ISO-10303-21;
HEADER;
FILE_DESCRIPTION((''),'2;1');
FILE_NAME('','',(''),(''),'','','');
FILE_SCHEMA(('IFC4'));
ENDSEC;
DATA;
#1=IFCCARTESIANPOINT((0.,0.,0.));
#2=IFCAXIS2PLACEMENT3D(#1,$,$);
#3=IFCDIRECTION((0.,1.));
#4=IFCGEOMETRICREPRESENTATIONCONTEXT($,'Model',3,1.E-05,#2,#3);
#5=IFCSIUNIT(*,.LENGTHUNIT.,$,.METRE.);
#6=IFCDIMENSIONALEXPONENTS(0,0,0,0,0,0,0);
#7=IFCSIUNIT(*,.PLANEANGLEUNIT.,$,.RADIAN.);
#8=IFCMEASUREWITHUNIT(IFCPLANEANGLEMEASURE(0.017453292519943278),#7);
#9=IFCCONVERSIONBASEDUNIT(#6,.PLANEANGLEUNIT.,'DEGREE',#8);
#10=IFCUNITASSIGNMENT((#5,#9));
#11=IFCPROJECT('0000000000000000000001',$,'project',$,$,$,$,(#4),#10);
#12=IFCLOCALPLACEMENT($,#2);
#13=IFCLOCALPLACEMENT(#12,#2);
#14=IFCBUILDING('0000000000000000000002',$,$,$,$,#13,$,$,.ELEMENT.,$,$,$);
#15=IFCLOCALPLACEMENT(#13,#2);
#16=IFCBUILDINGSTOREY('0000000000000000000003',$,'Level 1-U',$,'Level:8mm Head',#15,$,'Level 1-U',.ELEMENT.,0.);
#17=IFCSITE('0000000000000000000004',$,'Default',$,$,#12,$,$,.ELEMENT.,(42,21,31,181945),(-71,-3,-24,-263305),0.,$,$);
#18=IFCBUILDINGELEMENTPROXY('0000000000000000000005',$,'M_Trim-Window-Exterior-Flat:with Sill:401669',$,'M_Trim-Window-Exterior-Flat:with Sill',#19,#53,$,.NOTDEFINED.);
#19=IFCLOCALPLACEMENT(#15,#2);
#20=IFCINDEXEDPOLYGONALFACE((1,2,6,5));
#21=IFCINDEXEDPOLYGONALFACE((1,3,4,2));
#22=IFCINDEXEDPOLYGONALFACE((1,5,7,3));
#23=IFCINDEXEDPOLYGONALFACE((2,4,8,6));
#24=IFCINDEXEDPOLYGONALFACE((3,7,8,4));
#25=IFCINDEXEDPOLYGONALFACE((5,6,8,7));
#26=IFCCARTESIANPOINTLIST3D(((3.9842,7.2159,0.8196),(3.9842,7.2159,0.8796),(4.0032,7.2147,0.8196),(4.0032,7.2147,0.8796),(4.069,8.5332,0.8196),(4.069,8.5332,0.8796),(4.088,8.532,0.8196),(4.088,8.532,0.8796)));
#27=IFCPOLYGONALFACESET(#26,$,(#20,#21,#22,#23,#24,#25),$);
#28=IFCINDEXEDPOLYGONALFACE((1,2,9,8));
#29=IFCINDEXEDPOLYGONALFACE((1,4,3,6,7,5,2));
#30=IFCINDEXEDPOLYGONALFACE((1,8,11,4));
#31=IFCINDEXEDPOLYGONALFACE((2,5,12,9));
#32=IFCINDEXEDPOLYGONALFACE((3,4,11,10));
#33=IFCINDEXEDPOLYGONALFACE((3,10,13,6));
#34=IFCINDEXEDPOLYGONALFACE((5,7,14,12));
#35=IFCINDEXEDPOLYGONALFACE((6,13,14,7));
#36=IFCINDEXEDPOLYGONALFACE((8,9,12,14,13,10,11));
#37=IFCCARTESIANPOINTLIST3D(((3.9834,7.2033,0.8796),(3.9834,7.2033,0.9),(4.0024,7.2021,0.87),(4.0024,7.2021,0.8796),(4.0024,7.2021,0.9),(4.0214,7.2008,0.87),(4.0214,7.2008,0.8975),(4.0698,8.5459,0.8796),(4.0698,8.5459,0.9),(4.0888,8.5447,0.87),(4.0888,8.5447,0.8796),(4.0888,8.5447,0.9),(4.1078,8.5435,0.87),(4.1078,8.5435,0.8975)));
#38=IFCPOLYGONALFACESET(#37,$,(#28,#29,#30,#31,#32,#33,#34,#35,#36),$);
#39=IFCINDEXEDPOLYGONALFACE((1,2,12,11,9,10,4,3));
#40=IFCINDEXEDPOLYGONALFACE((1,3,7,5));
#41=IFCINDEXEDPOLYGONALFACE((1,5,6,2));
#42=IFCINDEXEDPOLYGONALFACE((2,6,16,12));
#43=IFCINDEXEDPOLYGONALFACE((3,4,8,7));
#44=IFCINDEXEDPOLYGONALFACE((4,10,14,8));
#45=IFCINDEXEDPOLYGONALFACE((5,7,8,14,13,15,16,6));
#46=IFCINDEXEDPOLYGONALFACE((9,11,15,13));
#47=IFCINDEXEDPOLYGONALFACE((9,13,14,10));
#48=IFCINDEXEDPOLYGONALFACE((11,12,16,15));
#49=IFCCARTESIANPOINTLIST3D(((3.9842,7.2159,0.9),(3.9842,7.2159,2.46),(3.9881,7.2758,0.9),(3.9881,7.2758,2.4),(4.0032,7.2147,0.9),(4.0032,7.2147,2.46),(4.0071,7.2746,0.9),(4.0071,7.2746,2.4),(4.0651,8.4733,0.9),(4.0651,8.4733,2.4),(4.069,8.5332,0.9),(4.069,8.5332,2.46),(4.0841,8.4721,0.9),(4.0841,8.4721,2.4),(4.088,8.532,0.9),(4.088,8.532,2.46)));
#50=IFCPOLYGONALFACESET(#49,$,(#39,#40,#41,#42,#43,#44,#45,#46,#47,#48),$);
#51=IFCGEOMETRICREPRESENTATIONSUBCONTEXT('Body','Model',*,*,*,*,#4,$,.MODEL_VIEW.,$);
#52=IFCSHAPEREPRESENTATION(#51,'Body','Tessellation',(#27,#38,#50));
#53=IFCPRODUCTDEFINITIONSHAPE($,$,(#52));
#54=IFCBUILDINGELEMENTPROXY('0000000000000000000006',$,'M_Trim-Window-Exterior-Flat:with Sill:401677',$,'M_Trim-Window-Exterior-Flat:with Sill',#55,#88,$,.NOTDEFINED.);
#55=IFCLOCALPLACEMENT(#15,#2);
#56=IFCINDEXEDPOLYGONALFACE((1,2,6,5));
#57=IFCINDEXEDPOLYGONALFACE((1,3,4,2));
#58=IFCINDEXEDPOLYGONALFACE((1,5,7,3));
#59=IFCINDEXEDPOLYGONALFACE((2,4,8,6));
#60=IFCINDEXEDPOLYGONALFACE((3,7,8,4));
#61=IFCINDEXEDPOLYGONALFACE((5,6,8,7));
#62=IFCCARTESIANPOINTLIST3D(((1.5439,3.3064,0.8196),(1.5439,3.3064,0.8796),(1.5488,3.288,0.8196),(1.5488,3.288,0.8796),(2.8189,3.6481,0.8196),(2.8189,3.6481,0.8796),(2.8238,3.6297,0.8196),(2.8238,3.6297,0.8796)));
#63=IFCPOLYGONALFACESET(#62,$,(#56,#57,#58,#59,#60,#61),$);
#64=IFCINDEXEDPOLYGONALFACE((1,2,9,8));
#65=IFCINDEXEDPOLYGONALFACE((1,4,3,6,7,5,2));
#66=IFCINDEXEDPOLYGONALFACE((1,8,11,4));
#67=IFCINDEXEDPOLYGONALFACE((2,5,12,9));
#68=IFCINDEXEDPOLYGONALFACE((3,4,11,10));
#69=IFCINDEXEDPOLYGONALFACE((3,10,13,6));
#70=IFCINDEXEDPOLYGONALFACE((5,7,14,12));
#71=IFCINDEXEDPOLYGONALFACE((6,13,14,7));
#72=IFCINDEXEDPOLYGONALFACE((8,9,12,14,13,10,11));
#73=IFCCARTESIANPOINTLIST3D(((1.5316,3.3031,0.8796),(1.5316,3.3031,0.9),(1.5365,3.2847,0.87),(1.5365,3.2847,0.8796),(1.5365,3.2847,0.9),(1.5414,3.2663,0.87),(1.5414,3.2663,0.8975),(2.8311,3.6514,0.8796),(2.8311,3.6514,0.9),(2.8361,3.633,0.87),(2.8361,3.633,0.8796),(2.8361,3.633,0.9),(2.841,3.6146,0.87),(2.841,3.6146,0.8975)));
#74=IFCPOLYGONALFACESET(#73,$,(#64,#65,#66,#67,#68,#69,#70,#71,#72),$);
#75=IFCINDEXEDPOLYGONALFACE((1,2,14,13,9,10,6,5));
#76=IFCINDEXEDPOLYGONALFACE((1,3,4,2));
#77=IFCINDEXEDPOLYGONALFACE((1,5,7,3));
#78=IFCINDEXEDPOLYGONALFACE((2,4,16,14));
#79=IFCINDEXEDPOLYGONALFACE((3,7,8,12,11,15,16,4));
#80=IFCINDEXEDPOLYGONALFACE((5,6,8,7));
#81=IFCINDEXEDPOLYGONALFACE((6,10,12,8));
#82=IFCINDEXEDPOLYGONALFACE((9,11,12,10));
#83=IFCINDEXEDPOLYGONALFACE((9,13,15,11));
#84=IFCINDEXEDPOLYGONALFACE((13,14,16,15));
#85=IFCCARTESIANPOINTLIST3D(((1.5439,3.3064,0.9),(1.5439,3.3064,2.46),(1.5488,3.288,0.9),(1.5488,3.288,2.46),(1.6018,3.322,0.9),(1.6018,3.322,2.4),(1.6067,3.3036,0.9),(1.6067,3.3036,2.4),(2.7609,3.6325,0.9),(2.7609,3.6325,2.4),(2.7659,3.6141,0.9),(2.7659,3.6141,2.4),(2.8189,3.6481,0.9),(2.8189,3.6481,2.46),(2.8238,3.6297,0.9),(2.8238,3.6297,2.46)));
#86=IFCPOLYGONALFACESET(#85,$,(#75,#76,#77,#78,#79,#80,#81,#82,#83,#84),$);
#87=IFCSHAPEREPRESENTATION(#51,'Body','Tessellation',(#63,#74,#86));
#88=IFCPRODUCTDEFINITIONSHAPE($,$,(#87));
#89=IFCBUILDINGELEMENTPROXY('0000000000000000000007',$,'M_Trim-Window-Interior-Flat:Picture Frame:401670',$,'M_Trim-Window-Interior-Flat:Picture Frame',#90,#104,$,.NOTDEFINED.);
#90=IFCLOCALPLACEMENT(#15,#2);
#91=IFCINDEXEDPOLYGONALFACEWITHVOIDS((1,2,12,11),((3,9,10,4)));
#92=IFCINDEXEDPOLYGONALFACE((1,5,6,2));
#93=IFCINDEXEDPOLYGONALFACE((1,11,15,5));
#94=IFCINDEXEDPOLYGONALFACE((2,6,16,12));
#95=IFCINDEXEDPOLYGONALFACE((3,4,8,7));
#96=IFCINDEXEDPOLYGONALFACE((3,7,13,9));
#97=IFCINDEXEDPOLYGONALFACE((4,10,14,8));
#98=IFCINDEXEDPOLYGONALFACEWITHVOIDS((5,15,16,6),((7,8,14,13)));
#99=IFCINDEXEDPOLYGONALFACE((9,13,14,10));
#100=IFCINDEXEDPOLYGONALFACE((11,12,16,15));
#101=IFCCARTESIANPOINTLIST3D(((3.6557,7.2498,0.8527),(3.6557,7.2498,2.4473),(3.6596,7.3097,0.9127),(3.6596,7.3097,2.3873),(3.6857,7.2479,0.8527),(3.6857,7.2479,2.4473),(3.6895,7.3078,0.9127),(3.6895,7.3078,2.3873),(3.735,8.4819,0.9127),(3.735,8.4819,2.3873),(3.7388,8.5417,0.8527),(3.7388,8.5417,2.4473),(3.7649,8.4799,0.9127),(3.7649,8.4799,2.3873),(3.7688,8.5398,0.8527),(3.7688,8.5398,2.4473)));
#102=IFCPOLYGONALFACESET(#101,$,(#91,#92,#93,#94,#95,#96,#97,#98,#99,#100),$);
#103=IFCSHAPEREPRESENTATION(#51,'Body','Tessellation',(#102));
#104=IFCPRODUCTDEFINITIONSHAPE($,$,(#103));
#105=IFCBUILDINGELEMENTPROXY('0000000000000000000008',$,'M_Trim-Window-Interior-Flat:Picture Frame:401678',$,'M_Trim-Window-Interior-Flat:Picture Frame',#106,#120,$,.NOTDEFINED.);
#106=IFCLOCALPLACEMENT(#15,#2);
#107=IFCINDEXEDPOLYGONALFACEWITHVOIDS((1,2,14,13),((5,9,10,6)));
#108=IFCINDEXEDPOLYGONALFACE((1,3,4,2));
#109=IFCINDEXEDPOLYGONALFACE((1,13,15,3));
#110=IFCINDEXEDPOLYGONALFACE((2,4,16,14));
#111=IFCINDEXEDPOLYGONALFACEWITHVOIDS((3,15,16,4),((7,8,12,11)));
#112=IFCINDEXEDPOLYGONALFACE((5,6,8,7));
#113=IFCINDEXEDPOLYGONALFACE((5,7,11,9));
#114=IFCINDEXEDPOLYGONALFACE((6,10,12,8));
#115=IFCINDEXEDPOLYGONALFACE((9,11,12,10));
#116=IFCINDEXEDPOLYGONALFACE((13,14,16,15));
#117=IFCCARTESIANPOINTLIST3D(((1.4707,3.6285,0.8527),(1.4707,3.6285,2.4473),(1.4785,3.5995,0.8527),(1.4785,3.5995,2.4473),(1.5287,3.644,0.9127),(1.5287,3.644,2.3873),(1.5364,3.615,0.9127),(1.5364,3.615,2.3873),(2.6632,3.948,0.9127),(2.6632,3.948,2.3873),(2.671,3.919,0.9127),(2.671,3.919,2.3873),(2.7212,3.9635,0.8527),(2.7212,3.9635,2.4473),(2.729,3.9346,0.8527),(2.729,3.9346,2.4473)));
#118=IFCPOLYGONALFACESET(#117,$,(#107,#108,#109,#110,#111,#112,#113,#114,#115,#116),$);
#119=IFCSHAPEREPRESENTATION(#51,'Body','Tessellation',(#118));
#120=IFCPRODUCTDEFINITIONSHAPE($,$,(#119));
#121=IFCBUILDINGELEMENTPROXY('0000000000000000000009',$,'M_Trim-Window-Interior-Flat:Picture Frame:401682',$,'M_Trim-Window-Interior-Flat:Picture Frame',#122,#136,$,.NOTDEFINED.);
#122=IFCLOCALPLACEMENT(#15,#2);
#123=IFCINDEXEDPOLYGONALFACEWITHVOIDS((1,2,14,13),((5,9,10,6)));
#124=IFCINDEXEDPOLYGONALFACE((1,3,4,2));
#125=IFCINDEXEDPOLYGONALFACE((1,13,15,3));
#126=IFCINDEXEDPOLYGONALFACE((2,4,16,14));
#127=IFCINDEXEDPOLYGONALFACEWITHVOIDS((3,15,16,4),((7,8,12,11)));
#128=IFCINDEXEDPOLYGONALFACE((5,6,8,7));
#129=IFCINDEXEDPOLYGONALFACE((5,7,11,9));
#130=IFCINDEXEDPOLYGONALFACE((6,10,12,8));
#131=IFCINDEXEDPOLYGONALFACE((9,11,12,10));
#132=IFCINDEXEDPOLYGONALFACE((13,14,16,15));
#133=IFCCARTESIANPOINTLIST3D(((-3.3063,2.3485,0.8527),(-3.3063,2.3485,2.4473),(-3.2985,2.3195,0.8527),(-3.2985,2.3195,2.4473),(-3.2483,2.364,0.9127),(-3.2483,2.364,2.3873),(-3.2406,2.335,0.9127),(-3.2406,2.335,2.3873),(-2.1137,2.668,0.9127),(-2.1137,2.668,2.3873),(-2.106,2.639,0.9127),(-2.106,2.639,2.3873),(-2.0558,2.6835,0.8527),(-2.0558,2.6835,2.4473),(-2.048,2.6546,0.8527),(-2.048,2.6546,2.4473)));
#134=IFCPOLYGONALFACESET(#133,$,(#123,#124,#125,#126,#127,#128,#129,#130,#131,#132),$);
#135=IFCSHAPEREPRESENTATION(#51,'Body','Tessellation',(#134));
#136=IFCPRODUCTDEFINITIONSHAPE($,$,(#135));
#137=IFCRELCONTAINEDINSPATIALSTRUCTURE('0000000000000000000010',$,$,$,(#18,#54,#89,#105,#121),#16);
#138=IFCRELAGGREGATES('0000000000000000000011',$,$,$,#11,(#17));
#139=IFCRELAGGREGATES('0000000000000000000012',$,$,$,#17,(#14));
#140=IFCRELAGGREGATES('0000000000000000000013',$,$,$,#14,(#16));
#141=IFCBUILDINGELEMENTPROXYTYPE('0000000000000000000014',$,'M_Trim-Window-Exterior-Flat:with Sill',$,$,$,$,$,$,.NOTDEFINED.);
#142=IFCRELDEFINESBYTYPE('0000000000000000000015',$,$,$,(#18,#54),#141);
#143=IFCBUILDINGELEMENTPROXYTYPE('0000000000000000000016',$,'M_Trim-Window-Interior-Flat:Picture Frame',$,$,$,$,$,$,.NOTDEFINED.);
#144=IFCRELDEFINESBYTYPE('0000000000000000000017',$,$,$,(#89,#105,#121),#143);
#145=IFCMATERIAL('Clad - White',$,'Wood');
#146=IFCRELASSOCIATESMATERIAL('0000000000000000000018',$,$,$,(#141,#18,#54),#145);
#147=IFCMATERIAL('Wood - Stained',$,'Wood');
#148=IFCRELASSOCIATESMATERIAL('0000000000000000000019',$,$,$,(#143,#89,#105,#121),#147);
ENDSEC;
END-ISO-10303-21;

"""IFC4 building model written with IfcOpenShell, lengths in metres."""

from ifc_helpers import new_model, entity, si_unit, converted_unit, direction, frame, frame_2d, origin, place, context, subcontext, project, spatial, polyline, rectangle, outline, extrude, source, transform, mapped, material, type_object, type_shapes, element, save


model = new_model("IFC4")

# Units and contexts
model_context = context("Model", 3, precision=1e-05, world=origin(), true_north=direction((0.0, 1.0)))
body_context = subcontext(model_context, "Body", "Model", "MODEL_VIEW")
ifc_project = project(units=[si_unit("LENGTHUNIT", "METRE"), converted_unit("PLANEANGLEUNIT", "DEGREE", entity("IfcPlaneAngleMeasure", 0.017453292519943278), si_unit("PLANEANGLEUNIT", "RADIAN"), dimensions=[0, 0, 0, 0, 0, 0, 0])], contexts=[model_context])

# Site, building, storey
site_placement = place(None, origin())
site = spatial("IfcSite", under=ifc_project, at=site_placement, Name="Default", CompositionType="ELEMENT", RefLatitude=(42, 21, 31, 181945), RefLongitude=(-71, -3, -24, -263305), RefElevation=0.0)
building_placement = place(site_placement, origin())
building = spatial("IfcBuilding", under=site, at=building_placement, CompositionType="ELEMENT")
storey_placement = place(building_placement, origin())
storey = spatial("IfcBuildingStorey", under=building, at=storey_placement, Name="Level 1-U", ObjectType="Level:8mm Head", LongName="Level 1-U", CompositionType="ELEMENT", Elevation=0.0)

# Building element proxies
ifc_material_1 = material(Name="Clad - White", Category="Wood")
ifc_material_2 = material(Name="Wood - Stained", Category="Wood")
building_element_proxy_type_1 = type_object("IfcBuildingElementProxyType", Name="M_Trim-Window-Exterior-Flat:with Sill", PredefinedType="NOTDEFINED", material=ifc_material_1)
shared_shape_1 = source(origin(), body_context, "Body", "SweptSolid", [
    extrude(rectangle(XDim=1.32, YDim=0.06, at=frame_2d((0.0, 0.0), x_axis=(1.0, 0.0))), frame((0.0, -1.5504, 0.0), z_axis=(0.0, 0.0, 1.0), x_axis=(-1.0, 0.0, 0.0)), (0.0, 0.0, 1.0), 0.019),
    extrude(outline(polyline([(-0.019, -0.0152), (0.0, -0.0152), (0.0, -0.0057), (0.019, -0.0057), (0.019, 0.0148), (0.0, 0.0148), (-0.019, 0.0123), (-0.019, -0.0152)])), frame((-0.6727, -1.5148, 0.019), z_axis=(1.0, 0.0, 0.0), x_axis=(0.0, 0.0, -1.0)), (0.0, 0.0, 1.0), 1.3454),
    extrude(outline(polyline([(-0.795, -0.66), (0.765, -0.66), (0.765, -0.6), (-0.735, -0.6), (-0.735, 0.6), (0.765, 0.6), (0.765, 0.66), (-0.795, 0.66), (-0.795, -0.66)])), frame((0.0, -0.735, 0.0), z_axis=(0.0, 0.0, 1.0), x_axis=(0.0, -1.0, 0.0)), (0.0, 0.0, 1.0), 0.019),
])
type_shapes(building_element_proxy_type_1, [shared_shape_1])
for number, where, z_axis, x_axis, name in (
    (1, (4.0266, 7.8746, 2.4), (0.997938, -0.064186, 0.0), (0.064186, 0.997938, 0.0), "M_Trim-Window-Exterior-Flat:with Sill:401669"),
    (2, (2.1814, 3.4772, 2.4), (0.258819, -0.965926, 0.0), (0.965926, 0.258819, 0.0), "M_Trim-Window-Exterior-Flat:with Sill:401677"),
):
    element("IfcBuildingElementProxy", number, at=place(storey_placement, frame(where, z_axis=z_axis, x_axis=x_axis)), inside=storey, type_object=building_element_proxy_type_1, material=ifc_material_1, Name=name, ObjectType="M_Trim-Window-Exterior-Flat:with Sill", PredefinedType="NOTDEFINED", context=body_context, shape_type="MappedRepresentation", body=[
        mapped(shared_shape_1, transform((0.0, 0.0, 0.0), scale=1.0)),
    ])
building_element_proxy_type_2 = type_object("IfcBuildingElementProxyType", Name="M_Trim-Window-Interior-Flat:Picture Frame", PredefinedType="NOTDEFINED", material=ifc_material_2)
shared_shape_2 = source(origin(), body_context, "Body", "SweptSolid", [
    extrude(outline(polyline([(-0.6473, -0.7973), (0.6473, -0.7973), (0.6473, 0.7973), (-0.6473, 0.7973), (-0.6473, -0.7973)]), holes=[polyline([(-0.5873, -0.7373), (-0.5873, 0.7373), (0.5873, 0.7373), (0.5873, -0.7373), (-0.5873, -0.7373)])]), frame((0.0, -0.75, 0.0), z_axis=(0.0, 0.0, 1.0), x_axis=(-1.0, 0.0, 0.0)), (0.0, 0.0, 1.0), 0.03),
])
type_shapes(building_element_proxy_type_2, [shared_shape_2])
for number, where, z_axis, x_axis, name in (
    (3, (3.7272, 7.8938, 2.4), (-0.997938, 0.064186, 0.0), (-0.064186, -0.997938, 0.0), "M_Trim-Window-Interior-Flat:Picture Frame:401670"),
    (4, (2.1037, 3.767, 2.4), (-0.258819, 0.965926, 0.0), (-0.965926, -0.258819, 0.0), "M_Trim-Window-Interior-Flat:Picture Frame:401678"),
    (5, (-2.6733, 2.487, 2.4), (-0.258819, 0.965926, 0.0), (-0.965926, -0.258819, 0.0), "M_Trim-Window-Interior-Flat:Picture Frame:401682"),
):
    element("IfcBuildingElementProxy", number, at=place(storey_placement, frame(where, z_axis=z_axis, x_axis=x_axis)), inside=storey, type_object=building_element_proxy_type_2, material=ifc_material_2, Name=name, ObjectType="M_Trim-Window-Interior-Flat:Picture Frame", PredefinedType="NOTDEFINED", context=body_context, shape_type="MappedRepresentation", body=[
        mapped(shared_shape_2, transform((0.0, 0.0, 0.0), scale=1.0)),
    ])

save(model, "model.ifc")
